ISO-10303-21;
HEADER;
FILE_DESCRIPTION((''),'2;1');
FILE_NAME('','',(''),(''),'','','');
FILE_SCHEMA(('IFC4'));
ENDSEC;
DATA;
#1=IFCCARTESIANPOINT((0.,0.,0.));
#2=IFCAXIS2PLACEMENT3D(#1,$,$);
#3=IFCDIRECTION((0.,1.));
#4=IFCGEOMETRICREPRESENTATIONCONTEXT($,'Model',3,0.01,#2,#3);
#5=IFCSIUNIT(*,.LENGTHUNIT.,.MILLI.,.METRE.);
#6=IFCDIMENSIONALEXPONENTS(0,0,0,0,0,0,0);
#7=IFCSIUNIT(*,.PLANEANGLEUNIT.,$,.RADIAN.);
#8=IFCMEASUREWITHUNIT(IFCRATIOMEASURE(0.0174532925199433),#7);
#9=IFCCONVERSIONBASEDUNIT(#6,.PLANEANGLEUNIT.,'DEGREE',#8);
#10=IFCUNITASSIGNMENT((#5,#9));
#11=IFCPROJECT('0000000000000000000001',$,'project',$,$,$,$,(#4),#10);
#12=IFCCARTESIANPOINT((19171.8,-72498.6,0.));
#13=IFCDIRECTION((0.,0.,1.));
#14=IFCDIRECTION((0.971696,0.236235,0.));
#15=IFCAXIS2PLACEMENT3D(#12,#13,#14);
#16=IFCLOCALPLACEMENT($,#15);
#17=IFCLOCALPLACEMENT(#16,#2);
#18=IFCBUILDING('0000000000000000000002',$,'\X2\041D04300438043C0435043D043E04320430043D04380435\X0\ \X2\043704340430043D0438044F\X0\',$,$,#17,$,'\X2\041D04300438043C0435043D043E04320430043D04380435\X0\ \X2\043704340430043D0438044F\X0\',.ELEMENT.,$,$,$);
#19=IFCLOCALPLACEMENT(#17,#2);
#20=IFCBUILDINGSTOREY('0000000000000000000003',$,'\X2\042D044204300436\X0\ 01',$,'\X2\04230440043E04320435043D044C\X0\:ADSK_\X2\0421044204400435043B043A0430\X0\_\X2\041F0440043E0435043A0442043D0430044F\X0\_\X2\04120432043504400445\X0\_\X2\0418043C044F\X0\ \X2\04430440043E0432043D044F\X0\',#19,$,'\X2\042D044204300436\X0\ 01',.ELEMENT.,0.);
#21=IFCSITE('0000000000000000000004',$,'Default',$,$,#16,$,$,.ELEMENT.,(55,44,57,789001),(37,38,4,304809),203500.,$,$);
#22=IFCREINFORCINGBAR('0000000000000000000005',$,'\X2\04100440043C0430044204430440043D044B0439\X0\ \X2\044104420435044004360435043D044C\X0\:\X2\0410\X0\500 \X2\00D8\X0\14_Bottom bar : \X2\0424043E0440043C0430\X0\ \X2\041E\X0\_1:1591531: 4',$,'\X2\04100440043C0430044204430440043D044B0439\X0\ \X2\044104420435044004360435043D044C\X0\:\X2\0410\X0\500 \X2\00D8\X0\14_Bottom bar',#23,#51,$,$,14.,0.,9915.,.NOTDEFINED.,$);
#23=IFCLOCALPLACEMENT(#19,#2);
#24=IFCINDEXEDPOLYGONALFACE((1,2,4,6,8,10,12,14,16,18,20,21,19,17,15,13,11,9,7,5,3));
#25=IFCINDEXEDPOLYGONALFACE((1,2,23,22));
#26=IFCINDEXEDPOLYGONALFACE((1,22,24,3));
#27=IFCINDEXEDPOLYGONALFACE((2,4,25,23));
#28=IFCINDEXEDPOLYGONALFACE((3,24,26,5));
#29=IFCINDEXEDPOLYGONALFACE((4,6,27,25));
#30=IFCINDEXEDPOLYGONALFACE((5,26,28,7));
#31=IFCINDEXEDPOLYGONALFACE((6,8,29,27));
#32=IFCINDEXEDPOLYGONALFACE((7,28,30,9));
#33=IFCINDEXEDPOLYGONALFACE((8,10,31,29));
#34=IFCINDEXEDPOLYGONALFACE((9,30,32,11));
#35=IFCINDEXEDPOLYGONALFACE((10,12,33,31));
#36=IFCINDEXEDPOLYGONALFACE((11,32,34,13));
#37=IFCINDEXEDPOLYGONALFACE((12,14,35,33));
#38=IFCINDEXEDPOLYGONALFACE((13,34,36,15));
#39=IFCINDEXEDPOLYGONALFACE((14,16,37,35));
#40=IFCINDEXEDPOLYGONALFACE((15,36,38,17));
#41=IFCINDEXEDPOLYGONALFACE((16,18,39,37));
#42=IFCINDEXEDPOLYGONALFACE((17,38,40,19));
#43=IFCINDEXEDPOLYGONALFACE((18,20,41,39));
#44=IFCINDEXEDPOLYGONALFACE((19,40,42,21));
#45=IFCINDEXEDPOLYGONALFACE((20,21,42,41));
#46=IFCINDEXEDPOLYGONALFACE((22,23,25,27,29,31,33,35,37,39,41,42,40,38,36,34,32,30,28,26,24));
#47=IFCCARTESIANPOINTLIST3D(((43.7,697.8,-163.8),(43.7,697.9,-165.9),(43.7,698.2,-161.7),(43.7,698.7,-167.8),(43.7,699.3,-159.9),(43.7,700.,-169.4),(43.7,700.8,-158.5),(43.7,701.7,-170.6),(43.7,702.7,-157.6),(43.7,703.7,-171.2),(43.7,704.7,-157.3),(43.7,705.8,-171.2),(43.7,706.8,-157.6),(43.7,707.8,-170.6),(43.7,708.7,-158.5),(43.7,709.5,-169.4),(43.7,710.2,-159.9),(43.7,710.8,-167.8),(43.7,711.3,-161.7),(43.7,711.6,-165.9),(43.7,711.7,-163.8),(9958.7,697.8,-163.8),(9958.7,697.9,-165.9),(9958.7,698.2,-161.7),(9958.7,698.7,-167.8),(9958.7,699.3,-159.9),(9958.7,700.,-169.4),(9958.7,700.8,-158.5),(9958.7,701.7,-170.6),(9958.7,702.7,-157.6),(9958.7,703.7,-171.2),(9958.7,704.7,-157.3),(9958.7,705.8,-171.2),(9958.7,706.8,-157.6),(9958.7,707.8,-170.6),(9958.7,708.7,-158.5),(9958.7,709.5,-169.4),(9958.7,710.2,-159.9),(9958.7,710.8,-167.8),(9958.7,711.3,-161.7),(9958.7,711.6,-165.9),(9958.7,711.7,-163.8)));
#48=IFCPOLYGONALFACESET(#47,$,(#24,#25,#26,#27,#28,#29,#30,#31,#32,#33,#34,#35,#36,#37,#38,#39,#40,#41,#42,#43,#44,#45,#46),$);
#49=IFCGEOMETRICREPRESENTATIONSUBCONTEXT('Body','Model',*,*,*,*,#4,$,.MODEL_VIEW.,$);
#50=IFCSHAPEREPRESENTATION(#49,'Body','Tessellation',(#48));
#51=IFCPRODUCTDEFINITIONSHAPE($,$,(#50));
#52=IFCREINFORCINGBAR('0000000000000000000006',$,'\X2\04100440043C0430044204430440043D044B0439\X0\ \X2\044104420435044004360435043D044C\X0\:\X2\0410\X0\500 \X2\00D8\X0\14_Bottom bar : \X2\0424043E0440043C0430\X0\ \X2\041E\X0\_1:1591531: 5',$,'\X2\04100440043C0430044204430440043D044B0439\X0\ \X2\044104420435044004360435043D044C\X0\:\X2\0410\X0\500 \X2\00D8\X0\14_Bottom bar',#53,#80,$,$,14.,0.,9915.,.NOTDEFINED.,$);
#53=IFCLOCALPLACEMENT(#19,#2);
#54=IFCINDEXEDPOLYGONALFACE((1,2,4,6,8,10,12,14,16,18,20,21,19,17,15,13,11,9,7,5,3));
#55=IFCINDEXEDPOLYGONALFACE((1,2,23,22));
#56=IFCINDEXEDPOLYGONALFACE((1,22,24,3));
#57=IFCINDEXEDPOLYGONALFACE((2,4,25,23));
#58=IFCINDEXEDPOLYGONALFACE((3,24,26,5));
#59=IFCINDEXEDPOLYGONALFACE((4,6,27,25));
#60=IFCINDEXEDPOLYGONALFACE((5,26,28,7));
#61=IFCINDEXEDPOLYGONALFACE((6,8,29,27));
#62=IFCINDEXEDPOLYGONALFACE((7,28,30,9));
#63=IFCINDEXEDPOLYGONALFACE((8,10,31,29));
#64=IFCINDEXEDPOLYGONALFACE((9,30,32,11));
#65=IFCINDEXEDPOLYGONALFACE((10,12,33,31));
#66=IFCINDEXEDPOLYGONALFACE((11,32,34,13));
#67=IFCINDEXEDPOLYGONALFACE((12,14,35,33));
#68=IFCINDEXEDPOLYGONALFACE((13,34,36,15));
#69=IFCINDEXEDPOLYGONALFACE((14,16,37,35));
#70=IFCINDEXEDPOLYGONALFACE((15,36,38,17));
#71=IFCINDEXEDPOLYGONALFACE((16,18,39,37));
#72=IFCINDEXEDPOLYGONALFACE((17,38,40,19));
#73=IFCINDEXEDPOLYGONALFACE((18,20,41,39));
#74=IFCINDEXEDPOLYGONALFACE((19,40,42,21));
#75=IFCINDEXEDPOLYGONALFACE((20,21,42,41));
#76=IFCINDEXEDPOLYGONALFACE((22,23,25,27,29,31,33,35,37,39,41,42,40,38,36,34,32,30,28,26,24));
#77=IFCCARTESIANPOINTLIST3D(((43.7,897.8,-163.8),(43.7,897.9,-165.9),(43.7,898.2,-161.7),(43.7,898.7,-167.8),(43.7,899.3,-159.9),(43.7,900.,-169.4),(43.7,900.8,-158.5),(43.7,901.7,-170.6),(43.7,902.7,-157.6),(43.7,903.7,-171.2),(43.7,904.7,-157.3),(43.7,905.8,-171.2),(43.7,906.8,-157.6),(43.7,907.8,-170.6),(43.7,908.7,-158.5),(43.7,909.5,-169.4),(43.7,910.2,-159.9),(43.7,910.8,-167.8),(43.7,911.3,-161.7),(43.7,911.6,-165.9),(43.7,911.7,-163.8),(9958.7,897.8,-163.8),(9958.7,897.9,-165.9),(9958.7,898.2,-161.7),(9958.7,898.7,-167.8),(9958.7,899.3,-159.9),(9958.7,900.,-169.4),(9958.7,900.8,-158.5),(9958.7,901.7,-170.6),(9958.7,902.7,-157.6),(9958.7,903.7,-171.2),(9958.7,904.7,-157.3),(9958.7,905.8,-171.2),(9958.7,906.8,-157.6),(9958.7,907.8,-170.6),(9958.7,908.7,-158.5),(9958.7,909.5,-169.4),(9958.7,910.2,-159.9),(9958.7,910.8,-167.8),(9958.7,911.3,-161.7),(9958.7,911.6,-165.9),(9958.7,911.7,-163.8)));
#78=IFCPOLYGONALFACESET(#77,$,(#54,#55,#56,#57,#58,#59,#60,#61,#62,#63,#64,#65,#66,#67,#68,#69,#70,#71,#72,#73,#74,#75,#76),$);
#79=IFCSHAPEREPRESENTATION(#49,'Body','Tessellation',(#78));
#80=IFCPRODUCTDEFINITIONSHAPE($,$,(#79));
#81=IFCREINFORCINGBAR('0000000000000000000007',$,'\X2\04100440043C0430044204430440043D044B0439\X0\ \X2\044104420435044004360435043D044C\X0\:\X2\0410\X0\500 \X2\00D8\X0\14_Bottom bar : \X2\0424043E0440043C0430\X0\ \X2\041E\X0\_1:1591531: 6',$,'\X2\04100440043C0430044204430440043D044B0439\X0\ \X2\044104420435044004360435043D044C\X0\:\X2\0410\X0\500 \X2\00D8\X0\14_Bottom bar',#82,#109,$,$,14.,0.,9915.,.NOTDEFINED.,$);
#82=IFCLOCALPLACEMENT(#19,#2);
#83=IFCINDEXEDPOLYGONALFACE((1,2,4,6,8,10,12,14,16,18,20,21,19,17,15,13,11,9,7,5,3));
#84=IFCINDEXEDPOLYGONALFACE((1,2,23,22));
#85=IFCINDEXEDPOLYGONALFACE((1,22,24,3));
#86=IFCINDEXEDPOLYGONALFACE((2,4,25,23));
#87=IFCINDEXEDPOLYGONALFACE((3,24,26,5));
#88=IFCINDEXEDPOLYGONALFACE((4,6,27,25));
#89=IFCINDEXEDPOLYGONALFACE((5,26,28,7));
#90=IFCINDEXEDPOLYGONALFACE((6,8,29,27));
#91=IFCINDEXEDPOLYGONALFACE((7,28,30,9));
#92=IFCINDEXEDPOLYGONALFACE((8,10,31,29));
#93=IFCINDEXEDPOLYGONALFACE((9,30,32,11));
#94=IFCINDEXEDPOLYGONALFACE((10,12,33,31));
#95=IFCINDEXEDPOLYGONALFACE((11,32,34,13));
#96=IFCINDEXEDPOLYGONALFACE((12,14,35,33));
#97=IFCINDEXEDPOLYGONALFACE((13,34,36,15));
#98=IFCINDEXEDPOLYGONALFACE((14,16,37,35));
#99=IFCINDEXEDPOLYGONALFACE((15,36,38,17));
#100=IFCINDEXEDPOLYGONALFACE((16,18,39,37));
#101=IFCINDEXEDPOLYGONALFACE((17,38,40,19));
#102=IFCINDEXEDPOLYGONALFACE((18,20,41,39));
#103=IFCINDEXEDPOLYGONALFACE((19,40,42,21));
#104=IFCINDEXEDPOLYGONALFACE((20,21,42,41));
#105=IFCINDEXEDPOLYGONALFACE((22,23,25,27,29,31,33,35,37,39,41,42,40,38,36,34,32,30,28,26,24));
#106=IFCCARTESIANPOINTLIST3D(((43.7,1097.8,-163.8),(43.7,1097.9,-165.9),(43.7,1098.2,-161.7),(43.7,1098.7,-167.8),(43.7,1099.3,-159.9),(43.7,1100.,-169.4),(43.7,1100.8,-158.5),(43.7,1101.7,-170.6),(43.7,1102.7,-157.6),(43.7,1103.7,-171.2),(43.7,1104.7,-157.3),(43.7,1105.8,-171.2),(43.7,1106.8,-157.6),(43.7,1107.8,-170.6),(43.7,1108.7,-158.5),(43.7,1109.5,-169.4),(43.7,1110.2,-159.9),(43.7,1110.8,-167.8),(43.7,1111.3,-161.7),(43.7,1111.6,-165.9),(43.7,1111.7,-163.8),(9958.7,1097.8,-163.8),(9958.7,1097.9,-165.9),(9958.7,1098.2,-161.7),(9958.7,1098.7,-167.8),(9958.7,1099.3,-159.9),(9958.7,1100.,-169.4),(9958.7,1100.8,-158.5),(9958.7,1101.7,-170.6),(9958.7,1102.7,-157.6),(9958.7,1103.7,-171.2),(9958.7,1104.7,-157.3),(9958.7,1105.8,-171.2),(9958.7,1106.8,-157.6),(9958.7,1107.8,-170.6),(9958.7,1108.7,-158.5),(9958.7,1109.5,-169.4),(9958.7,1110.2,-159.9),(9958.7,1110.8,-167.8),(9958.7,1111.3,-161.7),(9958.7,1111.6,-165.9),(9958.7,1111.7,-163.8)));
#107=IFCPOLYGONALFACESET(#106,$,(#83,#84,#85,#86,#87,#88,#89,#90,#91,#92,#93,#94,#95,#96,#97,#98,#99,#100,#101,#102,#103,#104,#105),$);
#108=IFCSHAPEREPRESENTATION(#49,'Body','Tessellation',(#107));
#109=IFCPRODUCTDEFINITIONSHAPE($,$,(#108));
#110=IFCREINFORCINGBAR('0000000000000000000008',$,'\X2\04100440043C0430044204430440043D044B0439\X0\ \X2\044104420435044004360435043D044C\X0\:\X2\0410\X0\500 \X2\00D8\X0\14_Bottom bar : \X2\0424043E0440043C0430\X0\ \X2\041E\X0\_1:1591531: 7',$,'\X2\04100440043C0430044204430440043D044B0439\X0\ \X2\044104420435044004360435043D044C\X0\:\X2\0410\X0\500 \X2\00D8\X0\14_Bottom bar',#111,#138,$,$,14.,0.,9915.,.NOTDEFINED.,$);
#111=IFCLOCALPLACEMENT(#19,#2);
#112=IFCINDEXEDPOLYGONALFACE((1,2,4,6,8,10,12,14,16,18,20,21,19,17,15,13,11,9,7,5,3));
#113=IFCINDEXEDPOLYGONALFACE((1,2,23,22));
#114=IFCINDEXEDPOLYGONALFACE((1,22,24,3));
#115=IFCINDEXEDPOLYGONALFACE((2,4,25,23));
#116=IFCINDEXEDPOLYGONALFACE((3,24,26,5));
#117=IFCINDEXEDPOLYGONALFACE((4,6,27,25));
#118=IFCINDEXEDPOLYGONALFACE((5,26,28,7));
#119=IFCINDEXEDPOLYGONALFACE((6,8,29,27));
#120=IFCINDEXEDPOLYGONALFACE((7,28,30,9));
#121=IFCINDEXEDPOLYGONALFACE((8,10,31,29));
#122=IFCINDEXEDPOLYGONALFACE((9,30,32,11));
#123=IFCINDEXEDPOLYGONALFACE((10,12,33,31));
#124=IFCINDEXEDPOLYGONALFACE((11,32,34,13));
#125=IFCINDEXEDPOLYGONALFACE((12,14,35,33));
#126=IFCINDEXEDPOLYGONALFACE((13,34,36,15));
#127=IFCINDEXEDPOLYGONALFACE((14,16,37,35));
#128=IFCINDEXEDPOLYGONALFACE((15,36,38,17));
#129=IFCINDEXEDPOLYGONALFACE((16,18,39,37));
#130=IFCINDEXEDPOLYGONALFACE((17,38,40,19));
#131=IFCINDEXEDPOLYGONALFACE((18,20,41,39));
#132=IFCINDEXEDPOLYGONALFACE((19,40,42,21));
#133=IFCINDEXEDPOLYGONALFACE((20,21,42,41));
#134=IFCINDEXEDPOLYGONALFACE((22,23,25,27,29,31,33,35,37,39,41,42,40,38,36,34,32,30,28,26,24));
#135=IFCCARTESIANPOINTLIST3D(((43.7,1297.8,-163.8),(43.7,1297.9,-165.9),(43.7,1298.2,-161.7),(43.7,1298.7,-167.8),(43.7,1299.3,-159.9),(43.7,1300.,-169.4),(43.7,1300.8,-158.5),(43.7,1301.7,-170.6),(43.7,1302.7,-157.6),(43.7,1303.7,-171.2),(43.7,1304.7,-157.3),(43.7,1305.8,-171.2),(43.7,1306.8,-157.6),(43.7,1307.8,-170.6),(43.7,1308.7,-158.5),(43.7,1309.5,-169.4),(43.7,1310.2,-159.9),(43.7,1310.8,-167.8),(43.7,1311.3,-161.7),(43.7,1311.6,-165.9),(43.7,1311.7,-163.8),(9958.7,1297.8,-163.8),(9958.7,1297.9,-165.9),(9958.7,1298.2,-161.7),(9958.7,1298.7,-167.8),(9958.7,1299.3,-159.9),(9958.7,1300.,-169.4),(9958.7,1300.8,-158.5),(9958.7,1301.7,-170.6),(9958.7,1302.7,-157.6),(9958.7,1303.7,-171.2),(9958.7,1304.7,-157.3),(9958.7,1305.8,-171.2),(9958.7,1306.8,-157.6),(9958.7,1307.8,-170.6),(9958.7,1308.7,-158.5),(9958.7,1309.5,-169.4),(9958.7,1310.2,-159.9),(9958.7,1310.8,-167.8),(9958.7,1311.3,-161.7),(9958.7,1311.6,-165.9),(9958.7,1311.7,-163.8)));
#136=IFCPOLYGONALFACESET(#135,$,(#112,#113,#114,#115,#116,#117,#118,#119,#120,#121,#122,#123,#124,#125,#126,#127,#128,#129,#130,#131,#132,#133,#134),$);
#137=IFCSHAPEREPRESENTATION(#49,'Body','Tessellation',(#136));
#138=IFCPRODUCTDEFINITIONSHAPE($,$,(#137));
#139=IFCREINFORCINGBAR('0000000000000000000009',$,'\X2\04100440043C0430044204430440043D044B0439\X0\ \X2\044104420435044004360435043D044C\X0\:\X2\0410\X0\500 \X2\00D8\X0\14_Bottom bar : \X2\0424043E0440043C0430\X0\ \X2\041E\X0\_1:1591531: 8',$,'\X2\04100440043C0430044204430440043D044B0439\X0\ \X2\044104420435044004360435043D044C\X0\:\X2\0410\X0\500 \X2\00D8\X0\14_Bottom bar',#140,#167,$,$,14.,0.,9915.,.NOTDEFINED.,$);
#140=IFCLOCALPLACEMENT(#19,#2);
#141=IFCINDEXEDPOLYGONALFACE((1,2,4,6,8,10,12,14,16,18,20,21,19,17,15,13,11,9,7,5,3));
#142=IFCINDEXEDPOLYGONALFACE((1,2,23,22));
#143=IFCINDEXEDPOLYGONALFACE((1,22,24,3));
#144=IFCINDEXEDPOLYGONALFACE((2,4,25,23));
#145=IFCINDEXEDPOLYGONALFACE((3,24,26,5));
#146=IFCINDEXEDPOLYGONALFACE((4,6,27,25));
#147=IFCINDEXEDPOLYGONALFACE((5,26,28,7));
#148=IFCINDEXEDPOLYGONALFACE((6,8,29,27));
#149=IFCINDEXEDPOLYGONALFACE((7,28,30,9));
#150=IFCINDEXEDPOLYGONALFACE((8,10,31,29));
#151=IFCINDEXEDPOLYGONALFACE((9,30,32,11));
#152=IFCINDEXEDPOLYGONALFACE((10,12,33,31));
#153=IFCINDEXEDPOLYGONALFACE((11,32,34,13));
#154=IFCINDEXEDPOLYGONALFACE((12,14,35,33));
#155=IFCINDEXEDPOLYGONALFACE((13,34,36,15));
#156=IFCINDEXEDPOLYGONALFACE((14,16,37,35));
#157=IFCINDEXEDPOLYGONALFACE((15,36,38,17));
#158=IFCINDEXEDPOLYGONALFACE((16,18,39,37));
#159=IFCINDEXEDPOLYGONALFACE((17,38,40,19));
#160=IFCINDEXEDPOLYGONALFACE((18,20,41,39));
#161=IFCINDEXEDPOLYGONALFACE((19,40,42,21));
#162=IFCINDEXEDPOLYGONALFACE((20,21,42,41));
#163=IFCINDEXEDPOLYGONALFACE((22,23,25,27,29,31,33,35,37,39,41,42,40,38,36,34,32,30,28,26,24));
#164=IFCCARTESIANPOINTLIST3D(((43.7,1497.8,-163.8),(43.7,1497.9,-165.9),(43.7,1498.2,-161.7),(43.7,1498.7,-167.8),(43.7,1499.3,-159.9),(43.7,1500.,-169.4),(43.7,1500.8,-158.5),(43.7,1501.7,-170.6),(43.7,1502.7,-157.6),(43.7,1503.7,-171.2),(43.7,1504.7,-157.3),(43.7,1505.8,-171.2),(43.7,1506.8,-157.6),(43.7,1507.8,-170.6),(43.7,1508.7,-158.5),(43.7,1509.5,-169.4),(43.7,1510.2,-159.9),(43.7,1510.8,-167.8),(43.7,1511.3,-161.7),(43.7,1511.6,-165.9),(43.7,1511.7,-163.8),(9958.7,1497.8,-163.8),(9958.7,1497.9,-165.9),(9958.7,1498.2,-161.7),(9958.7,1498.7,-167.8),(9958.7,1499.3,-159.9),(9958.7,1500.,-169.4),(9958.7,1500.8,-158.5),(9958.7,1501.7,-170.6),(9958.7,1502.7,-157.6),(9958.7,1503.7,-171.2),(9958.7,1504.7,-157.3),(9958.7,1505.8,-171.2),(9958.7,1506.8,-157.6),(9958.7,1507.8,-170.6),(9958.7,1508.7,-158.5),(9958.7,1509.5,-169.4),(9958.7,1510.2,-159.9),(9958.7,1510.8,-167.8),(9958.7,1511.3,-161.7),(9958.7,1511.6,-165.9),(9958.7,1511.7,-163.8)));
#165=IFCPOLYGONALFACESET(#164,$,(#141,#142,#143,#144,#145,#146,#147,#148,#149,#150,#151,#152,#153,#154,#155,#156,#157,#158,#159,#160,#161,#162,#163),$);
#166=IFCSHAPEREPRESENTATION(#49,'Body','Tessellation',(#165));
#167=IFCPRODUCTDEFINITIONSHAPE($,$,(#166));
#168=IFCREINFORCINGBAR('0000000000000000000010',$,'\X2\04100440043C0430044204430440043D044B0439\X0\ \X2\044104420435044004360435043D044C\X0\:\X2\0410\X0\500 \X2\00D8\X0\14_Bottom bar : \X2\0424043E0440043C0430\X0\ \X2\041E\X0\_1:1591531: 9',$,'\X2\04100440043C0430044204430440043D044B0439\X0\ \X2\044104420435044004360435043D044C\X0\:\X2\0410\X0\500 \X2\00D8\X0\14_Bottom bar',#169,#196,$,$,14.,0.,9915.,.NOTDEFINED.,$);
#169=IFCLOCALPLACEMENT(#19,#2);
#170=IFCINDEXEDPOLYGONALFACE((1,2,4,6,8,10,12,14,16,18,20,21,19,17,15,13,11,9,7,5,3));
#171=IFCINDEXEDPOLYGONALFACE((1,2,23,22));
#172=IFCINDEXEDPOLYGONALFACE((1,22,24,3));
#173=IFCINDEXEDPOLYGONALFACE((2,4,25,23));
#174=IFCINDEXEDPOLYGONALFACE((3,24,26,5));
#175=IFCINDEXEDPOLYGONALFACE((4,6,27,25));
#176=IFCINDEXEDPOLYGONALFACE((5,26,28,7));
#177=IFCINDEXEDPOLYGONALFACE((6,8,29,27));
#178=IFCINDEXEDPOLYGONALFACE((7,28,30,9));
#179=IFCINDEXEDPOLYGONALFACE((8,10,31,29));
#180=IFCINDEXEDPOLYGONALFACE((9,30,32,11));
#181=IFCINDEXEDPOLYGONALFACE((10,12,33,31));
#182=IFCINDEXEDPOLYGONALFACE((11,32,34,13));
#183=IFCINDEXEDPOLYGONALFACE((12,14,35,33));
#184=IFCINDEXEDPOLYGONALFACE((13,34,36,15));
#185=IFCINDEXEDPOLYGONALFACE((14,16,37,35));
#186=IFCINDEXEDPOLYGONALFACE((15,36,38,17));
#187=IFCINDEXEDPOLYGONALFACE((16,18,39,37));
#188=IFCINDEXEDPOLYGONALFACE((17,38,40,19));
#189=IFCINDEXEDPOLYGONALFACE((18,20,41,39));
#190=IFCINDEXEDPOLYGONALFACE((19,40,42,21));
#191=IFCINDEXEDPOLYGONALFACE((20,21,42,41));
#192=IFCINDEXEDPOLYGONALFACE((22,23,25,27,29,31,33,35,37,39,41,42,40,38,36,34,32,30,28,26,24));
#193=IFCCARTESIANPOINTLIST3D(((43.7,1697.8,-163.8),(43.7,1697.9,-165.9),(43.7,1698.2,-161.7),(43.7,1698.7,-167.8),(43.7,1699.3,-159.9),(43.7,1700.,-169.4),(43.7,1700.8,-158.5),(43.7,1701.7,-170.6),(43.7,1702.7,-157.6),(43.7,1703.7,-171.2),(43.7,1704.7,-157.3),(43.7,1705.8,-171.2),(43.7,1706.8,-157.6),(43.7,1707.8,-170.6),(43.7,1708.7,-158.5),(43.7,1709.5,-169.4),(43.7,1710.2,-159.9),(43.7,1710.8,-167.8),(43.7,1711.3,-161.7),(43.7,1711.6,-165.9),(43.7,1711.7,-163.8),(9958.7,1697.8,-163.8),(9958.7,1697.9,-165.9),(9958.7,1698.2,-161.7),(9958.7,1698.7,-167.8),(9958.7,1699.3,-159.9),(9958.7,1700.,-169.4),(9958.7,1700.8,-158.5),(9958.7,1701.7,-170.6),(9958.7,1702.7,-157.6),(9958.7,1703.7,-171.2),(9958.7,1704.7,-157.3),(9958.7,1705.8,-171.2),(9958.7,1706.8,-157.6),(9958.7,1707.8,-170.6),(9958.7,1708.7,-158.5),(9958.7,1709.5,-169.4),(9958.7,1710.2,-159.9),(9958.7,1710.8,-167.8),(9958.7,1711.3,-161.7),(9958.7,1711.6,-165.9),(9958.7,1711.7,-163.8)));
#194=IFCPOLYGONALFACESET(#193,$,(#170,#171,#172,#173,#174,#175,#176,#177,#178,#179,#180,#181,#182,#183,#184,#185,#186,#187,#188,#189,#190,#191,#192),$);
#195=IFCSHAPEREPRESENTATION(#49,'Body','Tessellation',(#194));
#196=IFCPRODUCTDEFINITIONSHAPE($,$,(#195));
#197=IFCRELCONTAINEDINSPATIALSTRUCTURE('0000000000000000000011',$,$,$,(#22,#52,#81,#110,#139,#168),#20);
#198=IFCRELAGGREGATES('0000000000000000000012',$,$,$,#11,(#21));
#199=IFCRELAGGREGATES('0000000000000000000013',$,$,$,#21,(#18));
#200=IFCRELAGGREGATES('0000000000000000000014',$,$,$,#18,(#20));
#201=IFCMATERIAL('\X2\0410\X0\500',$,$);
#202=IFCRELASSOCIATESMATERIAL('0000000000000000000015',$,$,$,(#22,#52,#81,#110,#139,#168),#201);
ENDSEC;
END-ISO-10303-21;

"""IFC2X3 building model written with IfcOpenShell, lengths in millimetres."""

from ifc_helpers import new_model, entity, si_unit, converted_unit, direction, frame, origin, place, context, subcontext, project, spatial, material, element, save


model = new_model("IFC2X3")

# Units and contexts
model_context = context("Model", 3, precision=0.01, world=origin(), true_north=direction((0.0, 1.0)))
body_context = subcontext(model_context, "Body", "Model", "MODEL_VIEW")
ifc_project = project(units=[si_unit("LENGTHUNIT", "METRE", prefix="MILLI"), converted_unit("PLANEANGLEUNIT", "DEGREE", entity("IfcRatioMeasure", 0.0174532925199433), si_unit("PLANEANGLEUNIT", "RADIAN"), dimensions=[0, 0, 0, 0, 0, 0, 0])], contexts=[model_context])

# Site, building, storey
site_placement = place(None, frame((19171.8, -72498.6, 0.0), z_axis=(0.0, 0.0, 1.0), x_axis=(0.971696, 0.236235, 0.0)))
site = spatial("IfcSite", under=ifc_project, at=site_placement, Name="Default", CompositionType="ELEMENT", RefLatitude=(55, 44, 57, 789001), RefLongitude=(37, 38, 4, 304809), RefElevation=203500.0)
building_placement = place(site_placement, origin())
building = spatial("IfcBuilding", under=site, at=building_placement, Name="Наименование здания", LongName="Наименование здания", CompositionType="ELEMENT")
storey_placement = place(building_placement, origin())
storey = spatial("IfcBuildingStorey", under=building, at=storey_placement, Name="Этаж 01", ObjectType="Уровень:ADSK_Стрелка_Проектная_Вверх_Имя уровня", LongName="Этаж 01", CompositionType="ELEMENT", Elevation=0.0)

# Reinforcing bars
ifc_material = material(Name="А500")
placement = place(storey_placement, origin())
element("IfcReinforcingBar", 1, at=placement, inside=storey, material=ifc_material, Name="Арматурный стержень:А500 Ø14_Bottom bar : Форма О_1:1591531: 4", ObjectType="Арматурный стержень:А500 Ø14_Bottom bar", BarLength=9915.0, BarRole="NOTDEFINED", CrossSectionArea=0.0, NominalDiameter=14.0, context=body_context, shape_type="AdvancedSweptSolid", body=[
    entity("IfcSweptDiskSolid", entity("IfcCompositeCurve", [entity("IfcCompositeCurveSegment", "CONTINUOUS", True, entity("IfcPolyline", [entity("IfcCartesianPoint", [43.7, 704.7, -164.3]), entity("IfcCartesianPoint", [9958.7, 704.7, -164.3])]))], False), 7.0, None, 0.0, 1.0),
])
element("IfcReinforcingBar", 2, at=placement, inside=storey, material=ifc_material, Name="Арматурный стержень:А500 Ø14_Bottom bar : Форма О_1:1591531: 5", ObjectType="Арматурный стержень:А500 Ø14_Bottom bar", BarLength=9915.0, BarRole="NOTDEFINED", CrossSectionArea=0.0, NominalDiameter=14.0, context=body_context, shape_type="AdvancedSweptSolid", body=[
    entity("IfcSweptDiskSolid", entity("IfcCompositeCurve", [entity("IfcCompositeCurveSegment", "CONTINUOUS", True, entity("IfcPolyline", [entity("IfcCartesianPoint", [43.7, 904.7, -164.3]), entity("IfcCartesianPoint", [9958.7, 904.7, -164.3])]))], False), 7.0, None, 0.0, 1.0),
])
element("IfcReinforcingBar", 3, at=placement, inside=storey, material=ifc_material, Name="Арматурный стержень:А500 Ø14_Bottom bar : Форма О_1:1591531: 6", ObjectType="Арматурный стержень:А500 Ø14_Bottom bar", BarLength=9915.0, BarRole="NOTDEFINED", CrossSectionArea=0.0, NominalDiameter=14.0, context=body_context, shape_type="AdvancedSweptSolid", body=[
    entity("IfcSweptDiskSolid", entity("IfcCompositeCurve", [entity("IfcCompositeCurveSegment", "CONTINUOUS", True, entity("IfcPolyline", [entity("IfcCartesianPoint", [43.7, 1104.7, -164.3]), entity("IfcCartesianPoint", [9958.7, 1104.7, -164.3])]))], False), 7.0, None, 0.0, 1.0),
])
element("IfcReinforcingBar", 4, at=placement, inside=storey, material=ifc_material, Name="Арматурный стержень:А500 Ø14_Bottom bar : Форма О_1:1591531: 7", ObjectType="Арматурный стержень:А500 Ø14_Bottom bar", BarLength=9915.0, BarRole="NOTDEFINED", CrossSectionArea=0.0, NominalDiameter=14.0, context=body_context, shape_type="AdvancedSweptSolid", body=[
    entity("IfcSweptDiskSolid", entity("IfcCompositeCurve", [entity("IfcCompositeCurveSegment", "CONTINUOUS", True, entity("IfcPolyline", [entity("IfcCartesianPoint", [43.7, 1304.7, -164.3]), entity("IfcCartesianPoint", [9958.7, 1304.7, -164.3])]))], False), 7.0, None, 0.0, 1.0),
])
element("IfcReinforcingBar", 5, at=placement, inside=storey, material=ifc_material, Name="Арматурный стержень:А500 Ø14_Bottom bar : Форма О_1:1591531: 8", ObjectType="Арматурный стержень:А500 Ø14_Bottom bar", BarLength=9915.0, BarRole="NOTDEFINED", CrossSectionArea=0.0, NominalDiameter=14.0, context=body_context, shape_type="AdvancedSweptSolid", body=[
    entity("IfcSweptDiskSolid", entity("IfcCompositeCurve", [entity("IfcCompositeCurveSegment", "CONTINUOUS", True, entity("IfcPolyline", [entity("IfcCartesianPoint", [43.7, 1504.7, -164.3]), entity("IfcCartesianPoint", [9958.7, 1504.7, -164.3])]))], False), 7.0, None, 0.0, 1.0),
])
element("IfcReinforcingBar", 6, at=placement, inside=storey, material=ifc_material, Name="Арматурный стержень:А500 Ø14_Bottom bar : Форма О_1:1591531: 9", ObjectType="Арматурный стержень:А500 Ø14_Bottom bar", BarLength=9915.0, BarRole="NOTDEFINED", CrossSectionArea=0.0, NominalDiameter=14.0, context=body_context, shape_type="AdvancedSweptSolid", body=[
    entity("IfcSweptDiskSolid", entity("IfcCompositeCurve", [entity("IfcCompositeCurveSegment", "CONTINUOUS", True, entity("IfcPolyline", [entity("IfcCartesianPoint", [43.7, 1704.7, -164.3]), entity("IfcCartesianPoint", [9958.7, 1704.7, -164.3])]))], False), 7.0, None, 0.0, 1.0),
])

save(model, "model.ifc")
